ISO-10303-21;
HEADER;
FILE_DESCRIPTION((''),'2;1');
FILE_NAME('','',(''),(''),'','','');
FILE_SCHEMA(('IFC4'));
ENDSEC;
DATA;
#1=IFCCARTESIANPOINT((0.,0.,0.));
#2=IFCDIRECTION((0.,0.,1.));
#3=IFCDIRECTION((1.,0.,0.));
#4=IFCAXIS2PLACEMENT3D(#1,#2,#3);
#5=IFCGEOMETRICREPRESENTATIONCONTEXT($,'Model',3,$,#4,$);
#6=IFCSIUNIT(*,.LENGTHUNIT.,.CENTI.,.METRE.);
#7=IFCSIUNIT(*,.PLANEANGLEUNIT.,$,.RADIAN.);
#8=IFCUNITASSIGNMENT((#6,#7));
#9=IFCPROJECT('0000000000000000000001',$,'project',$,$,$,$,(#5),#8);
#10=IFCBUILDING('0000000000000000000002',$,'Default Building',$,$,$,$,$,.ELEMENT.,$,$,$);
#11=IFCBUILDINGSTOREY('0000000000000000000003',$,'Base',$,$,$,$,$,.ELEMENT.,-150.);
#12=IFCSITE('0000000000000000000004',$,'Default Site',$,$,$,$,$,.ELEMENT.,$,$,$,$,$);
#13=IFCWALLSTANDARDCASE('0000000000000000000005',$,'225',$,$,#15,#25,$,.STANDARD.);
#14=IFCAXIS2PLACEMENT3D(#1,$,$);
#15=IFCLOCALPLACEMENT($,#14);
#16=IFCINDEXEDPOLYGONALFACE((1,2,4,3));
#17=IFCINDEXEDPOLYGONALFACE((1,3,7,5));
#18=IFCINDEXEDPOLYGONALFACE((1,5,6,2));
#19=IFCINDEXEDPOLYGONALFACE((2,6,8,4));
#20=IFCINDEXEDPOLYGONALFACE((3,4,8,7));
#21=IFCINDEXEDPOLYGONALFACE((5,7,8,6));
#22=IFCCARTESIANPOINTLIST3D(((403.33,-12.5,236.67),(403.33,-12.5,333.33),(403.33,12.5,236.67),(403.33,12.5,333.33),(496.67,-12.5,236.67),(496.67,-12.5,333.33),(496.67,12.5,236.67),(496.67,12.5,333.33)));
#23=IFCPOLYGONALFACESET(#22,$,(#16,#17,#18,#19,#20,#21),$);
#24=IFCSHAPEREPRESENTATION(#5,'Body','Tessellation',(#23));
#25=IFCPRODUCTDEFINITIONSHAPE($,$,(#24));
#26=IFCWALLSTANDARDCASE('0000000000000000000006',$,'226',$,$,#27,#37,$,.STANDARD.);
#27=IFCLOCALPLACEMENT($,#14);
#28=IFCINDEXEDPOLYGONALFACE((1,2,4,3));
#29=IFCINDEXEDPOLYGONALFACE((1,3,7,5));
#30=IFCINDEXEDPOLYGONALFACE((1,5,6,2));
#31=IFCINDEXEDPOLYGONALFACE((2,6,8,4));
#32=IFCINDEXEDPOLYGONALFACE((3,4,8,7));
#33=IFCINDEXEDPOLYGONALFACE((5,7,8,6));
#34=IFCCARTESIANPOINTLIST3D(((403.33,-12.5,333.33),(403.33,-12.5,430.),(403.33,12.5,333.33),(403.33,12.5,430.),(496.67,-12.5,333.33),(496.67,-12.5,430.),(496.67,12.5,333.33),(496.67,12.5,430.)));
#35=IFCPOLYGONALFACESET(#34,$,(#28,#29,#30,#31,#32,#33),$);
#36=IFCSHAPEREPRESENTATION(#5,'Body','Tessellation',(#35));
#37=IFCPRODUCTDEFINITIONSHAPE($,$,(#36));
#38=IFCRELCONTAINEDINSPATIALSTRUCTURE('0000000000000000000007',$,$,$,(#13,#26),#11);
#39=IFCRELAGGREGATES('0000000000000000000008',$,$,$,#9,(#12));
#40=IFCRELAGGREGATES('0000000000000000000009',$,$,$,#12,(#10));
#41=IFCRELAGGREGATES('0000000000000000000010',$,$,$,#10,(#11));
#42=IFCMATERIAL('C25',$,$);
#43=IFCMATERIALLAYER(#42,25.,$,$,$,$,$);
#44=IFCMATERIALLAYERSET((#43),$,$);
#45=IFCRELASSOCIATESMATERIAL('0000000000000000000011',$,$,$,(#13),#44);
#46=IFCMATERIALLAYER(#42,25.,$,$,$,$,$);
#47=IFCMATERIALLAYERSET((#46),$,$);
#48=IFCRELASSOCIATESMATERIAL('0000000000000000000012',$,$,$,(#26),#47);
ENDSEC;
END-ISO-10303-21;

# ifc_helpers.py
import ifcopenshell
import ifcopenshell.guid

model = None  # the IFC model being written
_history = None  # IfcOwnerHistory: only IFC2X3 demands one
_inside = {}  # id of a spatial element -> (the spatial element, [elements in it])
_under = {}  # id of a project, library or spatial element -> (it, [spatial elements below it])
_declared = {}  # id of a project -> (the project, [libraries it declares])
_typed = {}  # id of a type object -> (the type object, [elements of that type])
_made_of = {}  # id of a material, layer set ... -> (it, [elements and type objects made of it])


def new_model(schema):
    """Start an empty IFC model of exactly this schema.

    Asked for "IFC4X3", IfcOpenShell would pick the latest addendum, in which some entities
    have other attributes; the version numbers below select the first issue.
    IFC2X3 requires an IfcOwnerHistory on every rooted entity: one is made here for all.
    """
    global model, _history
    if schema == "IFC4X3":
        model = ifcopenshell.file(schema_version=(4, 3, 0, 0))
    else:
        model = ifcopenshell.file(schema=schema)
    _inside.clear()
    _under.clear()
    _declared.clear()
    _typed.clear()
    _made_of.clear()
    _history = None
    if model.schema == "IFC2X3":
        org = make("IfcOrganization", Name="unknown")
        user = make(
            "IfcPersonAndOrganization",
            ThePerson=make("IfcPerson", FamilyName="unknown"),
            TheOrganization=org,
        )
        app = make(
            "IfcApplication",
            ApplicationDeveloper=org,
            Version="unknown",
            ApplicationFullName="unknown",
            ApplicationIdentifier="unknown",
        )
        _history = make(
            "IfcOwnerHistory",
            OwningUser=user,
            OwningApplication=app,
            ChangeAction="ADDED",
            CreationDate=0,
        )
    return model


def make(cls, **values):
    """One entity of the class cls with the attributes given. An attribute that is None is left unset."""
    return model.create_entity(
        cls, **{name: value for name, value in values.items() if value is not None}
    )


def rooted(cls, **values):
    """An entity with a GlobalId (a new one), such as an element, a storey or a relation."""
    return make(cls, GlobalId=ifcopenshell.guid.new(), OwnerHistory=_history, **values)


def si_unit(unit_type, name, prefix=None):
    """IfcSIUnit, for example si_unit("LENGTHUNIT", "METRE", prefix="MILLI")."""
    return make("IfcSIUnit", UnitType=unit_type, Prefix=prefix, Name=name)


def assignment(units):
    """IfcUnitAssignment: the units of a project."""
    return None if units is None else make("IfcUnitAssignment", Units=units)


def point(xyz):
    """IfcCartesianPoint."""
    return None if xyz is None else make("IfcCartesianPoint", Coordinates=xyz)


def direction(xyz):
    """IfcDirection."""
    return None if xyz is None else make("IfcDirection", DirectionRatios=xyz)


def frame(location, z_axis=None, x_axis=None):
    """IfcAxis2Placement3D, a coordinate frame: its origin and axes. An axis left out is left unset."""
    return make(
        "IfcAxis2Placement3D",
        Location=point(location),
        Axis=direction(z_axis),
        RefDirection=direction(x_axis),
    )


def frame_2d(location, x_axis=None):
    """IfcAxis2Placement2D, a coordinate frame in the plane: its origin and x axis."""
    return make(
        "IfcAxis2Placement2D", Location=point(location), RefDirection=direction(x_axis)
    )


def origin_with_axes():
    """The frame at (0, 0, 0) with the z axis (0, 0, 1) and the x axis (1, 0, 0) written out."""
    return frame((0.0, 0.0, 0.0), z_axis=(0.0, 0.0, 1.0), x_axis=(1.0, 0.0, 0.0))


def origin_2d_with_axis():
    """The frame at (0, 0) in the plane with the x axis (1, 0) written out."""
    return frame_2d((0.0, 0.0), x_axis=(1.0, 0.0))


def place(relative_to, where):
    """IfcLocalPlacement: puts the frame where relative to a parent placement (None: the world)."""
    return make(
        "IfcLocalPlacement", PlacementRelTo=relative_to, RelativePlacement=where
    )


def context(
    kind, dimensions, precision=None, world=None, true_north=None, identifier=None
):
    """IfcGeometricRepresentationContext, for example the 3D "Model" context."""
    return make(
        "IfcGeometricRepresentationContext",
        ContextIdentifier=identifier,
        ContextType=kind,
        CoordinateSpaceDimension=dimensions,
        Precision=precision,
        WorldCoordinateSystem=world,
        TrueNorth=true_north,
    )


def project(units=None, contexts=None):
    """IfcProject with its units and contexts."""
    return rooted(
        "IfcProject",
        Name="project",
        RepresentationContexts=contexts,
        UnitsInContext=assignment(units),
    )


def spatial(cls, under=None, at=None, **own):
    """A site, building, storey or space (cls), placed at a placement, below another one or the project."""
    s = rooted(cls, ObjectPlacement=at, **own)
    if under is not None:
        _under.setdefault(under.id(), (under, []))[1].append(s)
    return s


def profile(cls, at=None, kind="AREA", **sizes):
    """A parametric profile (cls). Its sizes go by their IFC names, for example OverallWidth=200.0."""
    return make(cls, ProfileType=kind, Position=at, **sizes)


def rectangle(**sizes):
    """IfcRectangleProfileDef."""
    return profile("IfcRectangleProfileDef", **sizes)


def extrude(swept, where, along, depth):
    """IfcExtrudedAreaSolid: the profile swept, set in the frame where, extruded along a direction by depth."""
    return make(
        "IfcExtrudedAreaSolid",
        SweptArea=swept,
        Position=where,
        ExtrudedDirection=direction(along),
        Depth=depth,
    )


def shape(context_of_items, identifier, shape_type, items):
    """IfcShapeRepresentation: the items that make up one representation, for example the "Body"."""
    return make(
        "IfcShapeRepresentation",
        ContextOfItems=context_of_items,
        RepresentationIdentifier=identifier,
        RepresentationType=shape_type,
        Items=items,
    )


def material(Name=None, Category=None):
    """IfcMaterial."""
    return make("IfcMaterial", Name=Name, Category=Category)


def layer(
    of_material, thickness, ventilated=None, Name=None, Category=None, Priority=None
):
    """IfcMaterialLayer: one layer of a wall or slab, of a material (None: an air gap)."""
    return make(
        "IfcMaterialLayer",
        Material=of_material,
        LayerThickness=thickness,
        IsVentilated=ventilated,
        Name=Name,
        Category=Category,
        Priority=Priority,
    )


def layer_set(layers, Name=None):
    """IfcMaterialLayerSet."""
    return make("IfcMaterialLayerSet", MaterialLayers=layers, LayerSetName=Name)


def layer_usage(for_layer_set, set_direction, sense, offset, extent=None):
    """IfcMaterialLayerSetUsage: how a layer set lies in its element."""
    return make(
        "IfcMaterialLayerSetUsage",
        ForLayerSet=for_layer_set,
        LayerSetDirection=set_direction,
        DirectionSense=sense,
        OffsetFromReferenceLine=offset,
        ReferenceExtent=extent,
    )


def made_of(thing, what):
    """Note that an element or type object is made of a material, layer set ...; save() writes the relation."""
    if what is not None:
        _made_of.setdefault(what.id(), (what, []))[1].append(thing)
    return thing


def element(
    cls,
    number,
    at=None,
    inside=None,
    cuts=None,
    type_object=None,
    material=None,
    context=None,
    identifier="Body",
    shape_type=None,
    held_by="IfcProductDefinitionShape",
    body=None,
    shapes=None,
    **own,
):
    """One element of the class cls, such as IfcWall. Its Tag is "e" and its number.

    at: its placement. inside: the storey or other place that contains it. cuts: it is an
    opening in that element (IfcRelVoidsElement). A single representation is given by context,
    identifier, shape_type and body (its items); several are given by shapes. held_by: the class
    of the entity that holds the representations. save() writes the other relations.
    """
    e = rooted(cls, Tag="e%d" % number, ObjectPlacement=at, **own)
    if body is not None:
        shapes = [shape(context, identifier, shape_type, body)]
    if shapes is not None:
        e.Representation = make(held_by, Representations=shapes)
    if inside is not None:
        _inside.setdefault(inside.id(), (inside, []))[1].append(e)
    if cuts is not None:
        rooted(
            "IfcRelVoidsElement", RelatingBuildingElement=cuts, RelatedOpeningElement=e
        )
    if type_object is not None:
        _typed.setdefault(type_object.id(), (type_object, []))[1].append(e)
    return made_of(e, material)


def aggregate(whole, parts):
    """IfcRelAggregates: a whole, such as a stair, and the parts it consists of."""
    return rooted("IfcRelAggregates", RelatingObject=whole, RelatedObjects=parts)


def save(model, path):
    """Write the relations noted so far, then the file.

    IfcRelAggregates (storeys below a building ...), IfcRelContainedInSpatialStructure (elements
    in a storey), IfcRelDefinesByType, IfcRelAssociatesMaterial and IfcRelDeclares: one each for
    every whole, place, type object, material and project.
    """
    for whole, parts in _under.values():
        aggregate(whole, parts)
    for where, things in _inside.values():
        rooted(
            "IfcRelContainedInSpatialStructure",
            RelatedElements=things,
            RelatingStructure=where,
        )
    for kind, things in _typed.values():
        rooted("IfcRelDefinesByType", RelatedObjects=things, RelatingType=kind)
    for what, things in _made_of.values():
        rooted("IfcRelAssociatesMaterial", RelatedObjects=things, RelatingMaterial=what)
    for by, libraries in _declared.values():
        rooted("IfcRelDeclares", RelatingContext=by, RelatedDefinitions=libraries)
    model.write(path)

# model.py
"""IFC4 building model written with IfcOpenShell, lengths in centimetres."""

from ifc_helpers import new_model, si_unit, frame, origin_with_axes, origin_2d_with_axis, place, context, project, spatial, rectangle, extrude, material, layer, layer_set, layer_usage, element, save


model = new_model("IFC4")

# Units and contexts
model_context = context("Model", 3, world=origin_with_axes())
ifc_project = project(units=[si_unit("LENGTHUNIT", "METRE", prefix="CENTI"), si_unit("PLANEANGLEUNIT", "RADIAN")], contexts=[model_context])

# Site, building, storey
site = spatial("IfcSite", under=ifc_project, Name="Default Site", CompositionType="ELEMENT")
building = spatial("IfcBuilding", under=site, Name="Default Building", CompositionType="ELEMENT")
storey = spatial("IfcBuildingStorey", under=building, Name="Base", CompositionType="ELEMENT", Elevation=-150.0)

# Walls
ifc_material = material(Name="C25")
ifc_layer_1 = layer(ifc_material, 25.0)
ifc_layer_set_1 = layer_set([ifc_layer_1])
ifc_layer_usage_1 = layer_usage(ifc_layer_set_1, "AXIS2", "POSITIVE", -25.0)
wall_1_placement = place(None, frame((450.0, 0.0, 236.67), z_axis=(0.0, 0.0, 1.0), x_axis=(-1.0, 0.0, 0.0)))
element("IfcWallStandardCase", 1, at=wall_1_placement, inside=storey, material=ifc_layer_usage_1, Name="225", PredefinedType="STANDARD", context=model_context, shape_type="SweptSolid", body=[
    extrude(rectangle(XDim=93.33, YDim=25.0, at=origin_2d_with_axis()), origin_with_axes(), (0.0, 0.0, 1.0), 96.67),
])
ifc_layer_2 = layer(ifc_material, 25.0)
ifc_layer_set_2 = layer_set([ifc_layer_2])
ifc_layer_usage_2 = layer_usage(ifc_layer_set_2, "AXIS2", "POSITIVE", -25.0)
wall_2_placement = place(None, frame((450.0, 0.0, 333.33), z_axis=(0.0, 0.0, 1.0), x_axis=(-1.0, 0.0, 0.0)))
element("IfcWallStandardCase", 2, at=wall_2_placement, inside=storey, material=ifc_layer_usage_2, Name="226", PredefinedType="STANDARD", context=model_context, shape_type="SweptSolid", body=[
    extrude(rectangle(XDim=93.33, YDim=25.0, at=origin_2d_with_axis()), origin_with_axes(), (0.0, 0.0, 1.0), 96.67),
])

save(model, "model.ifc")
